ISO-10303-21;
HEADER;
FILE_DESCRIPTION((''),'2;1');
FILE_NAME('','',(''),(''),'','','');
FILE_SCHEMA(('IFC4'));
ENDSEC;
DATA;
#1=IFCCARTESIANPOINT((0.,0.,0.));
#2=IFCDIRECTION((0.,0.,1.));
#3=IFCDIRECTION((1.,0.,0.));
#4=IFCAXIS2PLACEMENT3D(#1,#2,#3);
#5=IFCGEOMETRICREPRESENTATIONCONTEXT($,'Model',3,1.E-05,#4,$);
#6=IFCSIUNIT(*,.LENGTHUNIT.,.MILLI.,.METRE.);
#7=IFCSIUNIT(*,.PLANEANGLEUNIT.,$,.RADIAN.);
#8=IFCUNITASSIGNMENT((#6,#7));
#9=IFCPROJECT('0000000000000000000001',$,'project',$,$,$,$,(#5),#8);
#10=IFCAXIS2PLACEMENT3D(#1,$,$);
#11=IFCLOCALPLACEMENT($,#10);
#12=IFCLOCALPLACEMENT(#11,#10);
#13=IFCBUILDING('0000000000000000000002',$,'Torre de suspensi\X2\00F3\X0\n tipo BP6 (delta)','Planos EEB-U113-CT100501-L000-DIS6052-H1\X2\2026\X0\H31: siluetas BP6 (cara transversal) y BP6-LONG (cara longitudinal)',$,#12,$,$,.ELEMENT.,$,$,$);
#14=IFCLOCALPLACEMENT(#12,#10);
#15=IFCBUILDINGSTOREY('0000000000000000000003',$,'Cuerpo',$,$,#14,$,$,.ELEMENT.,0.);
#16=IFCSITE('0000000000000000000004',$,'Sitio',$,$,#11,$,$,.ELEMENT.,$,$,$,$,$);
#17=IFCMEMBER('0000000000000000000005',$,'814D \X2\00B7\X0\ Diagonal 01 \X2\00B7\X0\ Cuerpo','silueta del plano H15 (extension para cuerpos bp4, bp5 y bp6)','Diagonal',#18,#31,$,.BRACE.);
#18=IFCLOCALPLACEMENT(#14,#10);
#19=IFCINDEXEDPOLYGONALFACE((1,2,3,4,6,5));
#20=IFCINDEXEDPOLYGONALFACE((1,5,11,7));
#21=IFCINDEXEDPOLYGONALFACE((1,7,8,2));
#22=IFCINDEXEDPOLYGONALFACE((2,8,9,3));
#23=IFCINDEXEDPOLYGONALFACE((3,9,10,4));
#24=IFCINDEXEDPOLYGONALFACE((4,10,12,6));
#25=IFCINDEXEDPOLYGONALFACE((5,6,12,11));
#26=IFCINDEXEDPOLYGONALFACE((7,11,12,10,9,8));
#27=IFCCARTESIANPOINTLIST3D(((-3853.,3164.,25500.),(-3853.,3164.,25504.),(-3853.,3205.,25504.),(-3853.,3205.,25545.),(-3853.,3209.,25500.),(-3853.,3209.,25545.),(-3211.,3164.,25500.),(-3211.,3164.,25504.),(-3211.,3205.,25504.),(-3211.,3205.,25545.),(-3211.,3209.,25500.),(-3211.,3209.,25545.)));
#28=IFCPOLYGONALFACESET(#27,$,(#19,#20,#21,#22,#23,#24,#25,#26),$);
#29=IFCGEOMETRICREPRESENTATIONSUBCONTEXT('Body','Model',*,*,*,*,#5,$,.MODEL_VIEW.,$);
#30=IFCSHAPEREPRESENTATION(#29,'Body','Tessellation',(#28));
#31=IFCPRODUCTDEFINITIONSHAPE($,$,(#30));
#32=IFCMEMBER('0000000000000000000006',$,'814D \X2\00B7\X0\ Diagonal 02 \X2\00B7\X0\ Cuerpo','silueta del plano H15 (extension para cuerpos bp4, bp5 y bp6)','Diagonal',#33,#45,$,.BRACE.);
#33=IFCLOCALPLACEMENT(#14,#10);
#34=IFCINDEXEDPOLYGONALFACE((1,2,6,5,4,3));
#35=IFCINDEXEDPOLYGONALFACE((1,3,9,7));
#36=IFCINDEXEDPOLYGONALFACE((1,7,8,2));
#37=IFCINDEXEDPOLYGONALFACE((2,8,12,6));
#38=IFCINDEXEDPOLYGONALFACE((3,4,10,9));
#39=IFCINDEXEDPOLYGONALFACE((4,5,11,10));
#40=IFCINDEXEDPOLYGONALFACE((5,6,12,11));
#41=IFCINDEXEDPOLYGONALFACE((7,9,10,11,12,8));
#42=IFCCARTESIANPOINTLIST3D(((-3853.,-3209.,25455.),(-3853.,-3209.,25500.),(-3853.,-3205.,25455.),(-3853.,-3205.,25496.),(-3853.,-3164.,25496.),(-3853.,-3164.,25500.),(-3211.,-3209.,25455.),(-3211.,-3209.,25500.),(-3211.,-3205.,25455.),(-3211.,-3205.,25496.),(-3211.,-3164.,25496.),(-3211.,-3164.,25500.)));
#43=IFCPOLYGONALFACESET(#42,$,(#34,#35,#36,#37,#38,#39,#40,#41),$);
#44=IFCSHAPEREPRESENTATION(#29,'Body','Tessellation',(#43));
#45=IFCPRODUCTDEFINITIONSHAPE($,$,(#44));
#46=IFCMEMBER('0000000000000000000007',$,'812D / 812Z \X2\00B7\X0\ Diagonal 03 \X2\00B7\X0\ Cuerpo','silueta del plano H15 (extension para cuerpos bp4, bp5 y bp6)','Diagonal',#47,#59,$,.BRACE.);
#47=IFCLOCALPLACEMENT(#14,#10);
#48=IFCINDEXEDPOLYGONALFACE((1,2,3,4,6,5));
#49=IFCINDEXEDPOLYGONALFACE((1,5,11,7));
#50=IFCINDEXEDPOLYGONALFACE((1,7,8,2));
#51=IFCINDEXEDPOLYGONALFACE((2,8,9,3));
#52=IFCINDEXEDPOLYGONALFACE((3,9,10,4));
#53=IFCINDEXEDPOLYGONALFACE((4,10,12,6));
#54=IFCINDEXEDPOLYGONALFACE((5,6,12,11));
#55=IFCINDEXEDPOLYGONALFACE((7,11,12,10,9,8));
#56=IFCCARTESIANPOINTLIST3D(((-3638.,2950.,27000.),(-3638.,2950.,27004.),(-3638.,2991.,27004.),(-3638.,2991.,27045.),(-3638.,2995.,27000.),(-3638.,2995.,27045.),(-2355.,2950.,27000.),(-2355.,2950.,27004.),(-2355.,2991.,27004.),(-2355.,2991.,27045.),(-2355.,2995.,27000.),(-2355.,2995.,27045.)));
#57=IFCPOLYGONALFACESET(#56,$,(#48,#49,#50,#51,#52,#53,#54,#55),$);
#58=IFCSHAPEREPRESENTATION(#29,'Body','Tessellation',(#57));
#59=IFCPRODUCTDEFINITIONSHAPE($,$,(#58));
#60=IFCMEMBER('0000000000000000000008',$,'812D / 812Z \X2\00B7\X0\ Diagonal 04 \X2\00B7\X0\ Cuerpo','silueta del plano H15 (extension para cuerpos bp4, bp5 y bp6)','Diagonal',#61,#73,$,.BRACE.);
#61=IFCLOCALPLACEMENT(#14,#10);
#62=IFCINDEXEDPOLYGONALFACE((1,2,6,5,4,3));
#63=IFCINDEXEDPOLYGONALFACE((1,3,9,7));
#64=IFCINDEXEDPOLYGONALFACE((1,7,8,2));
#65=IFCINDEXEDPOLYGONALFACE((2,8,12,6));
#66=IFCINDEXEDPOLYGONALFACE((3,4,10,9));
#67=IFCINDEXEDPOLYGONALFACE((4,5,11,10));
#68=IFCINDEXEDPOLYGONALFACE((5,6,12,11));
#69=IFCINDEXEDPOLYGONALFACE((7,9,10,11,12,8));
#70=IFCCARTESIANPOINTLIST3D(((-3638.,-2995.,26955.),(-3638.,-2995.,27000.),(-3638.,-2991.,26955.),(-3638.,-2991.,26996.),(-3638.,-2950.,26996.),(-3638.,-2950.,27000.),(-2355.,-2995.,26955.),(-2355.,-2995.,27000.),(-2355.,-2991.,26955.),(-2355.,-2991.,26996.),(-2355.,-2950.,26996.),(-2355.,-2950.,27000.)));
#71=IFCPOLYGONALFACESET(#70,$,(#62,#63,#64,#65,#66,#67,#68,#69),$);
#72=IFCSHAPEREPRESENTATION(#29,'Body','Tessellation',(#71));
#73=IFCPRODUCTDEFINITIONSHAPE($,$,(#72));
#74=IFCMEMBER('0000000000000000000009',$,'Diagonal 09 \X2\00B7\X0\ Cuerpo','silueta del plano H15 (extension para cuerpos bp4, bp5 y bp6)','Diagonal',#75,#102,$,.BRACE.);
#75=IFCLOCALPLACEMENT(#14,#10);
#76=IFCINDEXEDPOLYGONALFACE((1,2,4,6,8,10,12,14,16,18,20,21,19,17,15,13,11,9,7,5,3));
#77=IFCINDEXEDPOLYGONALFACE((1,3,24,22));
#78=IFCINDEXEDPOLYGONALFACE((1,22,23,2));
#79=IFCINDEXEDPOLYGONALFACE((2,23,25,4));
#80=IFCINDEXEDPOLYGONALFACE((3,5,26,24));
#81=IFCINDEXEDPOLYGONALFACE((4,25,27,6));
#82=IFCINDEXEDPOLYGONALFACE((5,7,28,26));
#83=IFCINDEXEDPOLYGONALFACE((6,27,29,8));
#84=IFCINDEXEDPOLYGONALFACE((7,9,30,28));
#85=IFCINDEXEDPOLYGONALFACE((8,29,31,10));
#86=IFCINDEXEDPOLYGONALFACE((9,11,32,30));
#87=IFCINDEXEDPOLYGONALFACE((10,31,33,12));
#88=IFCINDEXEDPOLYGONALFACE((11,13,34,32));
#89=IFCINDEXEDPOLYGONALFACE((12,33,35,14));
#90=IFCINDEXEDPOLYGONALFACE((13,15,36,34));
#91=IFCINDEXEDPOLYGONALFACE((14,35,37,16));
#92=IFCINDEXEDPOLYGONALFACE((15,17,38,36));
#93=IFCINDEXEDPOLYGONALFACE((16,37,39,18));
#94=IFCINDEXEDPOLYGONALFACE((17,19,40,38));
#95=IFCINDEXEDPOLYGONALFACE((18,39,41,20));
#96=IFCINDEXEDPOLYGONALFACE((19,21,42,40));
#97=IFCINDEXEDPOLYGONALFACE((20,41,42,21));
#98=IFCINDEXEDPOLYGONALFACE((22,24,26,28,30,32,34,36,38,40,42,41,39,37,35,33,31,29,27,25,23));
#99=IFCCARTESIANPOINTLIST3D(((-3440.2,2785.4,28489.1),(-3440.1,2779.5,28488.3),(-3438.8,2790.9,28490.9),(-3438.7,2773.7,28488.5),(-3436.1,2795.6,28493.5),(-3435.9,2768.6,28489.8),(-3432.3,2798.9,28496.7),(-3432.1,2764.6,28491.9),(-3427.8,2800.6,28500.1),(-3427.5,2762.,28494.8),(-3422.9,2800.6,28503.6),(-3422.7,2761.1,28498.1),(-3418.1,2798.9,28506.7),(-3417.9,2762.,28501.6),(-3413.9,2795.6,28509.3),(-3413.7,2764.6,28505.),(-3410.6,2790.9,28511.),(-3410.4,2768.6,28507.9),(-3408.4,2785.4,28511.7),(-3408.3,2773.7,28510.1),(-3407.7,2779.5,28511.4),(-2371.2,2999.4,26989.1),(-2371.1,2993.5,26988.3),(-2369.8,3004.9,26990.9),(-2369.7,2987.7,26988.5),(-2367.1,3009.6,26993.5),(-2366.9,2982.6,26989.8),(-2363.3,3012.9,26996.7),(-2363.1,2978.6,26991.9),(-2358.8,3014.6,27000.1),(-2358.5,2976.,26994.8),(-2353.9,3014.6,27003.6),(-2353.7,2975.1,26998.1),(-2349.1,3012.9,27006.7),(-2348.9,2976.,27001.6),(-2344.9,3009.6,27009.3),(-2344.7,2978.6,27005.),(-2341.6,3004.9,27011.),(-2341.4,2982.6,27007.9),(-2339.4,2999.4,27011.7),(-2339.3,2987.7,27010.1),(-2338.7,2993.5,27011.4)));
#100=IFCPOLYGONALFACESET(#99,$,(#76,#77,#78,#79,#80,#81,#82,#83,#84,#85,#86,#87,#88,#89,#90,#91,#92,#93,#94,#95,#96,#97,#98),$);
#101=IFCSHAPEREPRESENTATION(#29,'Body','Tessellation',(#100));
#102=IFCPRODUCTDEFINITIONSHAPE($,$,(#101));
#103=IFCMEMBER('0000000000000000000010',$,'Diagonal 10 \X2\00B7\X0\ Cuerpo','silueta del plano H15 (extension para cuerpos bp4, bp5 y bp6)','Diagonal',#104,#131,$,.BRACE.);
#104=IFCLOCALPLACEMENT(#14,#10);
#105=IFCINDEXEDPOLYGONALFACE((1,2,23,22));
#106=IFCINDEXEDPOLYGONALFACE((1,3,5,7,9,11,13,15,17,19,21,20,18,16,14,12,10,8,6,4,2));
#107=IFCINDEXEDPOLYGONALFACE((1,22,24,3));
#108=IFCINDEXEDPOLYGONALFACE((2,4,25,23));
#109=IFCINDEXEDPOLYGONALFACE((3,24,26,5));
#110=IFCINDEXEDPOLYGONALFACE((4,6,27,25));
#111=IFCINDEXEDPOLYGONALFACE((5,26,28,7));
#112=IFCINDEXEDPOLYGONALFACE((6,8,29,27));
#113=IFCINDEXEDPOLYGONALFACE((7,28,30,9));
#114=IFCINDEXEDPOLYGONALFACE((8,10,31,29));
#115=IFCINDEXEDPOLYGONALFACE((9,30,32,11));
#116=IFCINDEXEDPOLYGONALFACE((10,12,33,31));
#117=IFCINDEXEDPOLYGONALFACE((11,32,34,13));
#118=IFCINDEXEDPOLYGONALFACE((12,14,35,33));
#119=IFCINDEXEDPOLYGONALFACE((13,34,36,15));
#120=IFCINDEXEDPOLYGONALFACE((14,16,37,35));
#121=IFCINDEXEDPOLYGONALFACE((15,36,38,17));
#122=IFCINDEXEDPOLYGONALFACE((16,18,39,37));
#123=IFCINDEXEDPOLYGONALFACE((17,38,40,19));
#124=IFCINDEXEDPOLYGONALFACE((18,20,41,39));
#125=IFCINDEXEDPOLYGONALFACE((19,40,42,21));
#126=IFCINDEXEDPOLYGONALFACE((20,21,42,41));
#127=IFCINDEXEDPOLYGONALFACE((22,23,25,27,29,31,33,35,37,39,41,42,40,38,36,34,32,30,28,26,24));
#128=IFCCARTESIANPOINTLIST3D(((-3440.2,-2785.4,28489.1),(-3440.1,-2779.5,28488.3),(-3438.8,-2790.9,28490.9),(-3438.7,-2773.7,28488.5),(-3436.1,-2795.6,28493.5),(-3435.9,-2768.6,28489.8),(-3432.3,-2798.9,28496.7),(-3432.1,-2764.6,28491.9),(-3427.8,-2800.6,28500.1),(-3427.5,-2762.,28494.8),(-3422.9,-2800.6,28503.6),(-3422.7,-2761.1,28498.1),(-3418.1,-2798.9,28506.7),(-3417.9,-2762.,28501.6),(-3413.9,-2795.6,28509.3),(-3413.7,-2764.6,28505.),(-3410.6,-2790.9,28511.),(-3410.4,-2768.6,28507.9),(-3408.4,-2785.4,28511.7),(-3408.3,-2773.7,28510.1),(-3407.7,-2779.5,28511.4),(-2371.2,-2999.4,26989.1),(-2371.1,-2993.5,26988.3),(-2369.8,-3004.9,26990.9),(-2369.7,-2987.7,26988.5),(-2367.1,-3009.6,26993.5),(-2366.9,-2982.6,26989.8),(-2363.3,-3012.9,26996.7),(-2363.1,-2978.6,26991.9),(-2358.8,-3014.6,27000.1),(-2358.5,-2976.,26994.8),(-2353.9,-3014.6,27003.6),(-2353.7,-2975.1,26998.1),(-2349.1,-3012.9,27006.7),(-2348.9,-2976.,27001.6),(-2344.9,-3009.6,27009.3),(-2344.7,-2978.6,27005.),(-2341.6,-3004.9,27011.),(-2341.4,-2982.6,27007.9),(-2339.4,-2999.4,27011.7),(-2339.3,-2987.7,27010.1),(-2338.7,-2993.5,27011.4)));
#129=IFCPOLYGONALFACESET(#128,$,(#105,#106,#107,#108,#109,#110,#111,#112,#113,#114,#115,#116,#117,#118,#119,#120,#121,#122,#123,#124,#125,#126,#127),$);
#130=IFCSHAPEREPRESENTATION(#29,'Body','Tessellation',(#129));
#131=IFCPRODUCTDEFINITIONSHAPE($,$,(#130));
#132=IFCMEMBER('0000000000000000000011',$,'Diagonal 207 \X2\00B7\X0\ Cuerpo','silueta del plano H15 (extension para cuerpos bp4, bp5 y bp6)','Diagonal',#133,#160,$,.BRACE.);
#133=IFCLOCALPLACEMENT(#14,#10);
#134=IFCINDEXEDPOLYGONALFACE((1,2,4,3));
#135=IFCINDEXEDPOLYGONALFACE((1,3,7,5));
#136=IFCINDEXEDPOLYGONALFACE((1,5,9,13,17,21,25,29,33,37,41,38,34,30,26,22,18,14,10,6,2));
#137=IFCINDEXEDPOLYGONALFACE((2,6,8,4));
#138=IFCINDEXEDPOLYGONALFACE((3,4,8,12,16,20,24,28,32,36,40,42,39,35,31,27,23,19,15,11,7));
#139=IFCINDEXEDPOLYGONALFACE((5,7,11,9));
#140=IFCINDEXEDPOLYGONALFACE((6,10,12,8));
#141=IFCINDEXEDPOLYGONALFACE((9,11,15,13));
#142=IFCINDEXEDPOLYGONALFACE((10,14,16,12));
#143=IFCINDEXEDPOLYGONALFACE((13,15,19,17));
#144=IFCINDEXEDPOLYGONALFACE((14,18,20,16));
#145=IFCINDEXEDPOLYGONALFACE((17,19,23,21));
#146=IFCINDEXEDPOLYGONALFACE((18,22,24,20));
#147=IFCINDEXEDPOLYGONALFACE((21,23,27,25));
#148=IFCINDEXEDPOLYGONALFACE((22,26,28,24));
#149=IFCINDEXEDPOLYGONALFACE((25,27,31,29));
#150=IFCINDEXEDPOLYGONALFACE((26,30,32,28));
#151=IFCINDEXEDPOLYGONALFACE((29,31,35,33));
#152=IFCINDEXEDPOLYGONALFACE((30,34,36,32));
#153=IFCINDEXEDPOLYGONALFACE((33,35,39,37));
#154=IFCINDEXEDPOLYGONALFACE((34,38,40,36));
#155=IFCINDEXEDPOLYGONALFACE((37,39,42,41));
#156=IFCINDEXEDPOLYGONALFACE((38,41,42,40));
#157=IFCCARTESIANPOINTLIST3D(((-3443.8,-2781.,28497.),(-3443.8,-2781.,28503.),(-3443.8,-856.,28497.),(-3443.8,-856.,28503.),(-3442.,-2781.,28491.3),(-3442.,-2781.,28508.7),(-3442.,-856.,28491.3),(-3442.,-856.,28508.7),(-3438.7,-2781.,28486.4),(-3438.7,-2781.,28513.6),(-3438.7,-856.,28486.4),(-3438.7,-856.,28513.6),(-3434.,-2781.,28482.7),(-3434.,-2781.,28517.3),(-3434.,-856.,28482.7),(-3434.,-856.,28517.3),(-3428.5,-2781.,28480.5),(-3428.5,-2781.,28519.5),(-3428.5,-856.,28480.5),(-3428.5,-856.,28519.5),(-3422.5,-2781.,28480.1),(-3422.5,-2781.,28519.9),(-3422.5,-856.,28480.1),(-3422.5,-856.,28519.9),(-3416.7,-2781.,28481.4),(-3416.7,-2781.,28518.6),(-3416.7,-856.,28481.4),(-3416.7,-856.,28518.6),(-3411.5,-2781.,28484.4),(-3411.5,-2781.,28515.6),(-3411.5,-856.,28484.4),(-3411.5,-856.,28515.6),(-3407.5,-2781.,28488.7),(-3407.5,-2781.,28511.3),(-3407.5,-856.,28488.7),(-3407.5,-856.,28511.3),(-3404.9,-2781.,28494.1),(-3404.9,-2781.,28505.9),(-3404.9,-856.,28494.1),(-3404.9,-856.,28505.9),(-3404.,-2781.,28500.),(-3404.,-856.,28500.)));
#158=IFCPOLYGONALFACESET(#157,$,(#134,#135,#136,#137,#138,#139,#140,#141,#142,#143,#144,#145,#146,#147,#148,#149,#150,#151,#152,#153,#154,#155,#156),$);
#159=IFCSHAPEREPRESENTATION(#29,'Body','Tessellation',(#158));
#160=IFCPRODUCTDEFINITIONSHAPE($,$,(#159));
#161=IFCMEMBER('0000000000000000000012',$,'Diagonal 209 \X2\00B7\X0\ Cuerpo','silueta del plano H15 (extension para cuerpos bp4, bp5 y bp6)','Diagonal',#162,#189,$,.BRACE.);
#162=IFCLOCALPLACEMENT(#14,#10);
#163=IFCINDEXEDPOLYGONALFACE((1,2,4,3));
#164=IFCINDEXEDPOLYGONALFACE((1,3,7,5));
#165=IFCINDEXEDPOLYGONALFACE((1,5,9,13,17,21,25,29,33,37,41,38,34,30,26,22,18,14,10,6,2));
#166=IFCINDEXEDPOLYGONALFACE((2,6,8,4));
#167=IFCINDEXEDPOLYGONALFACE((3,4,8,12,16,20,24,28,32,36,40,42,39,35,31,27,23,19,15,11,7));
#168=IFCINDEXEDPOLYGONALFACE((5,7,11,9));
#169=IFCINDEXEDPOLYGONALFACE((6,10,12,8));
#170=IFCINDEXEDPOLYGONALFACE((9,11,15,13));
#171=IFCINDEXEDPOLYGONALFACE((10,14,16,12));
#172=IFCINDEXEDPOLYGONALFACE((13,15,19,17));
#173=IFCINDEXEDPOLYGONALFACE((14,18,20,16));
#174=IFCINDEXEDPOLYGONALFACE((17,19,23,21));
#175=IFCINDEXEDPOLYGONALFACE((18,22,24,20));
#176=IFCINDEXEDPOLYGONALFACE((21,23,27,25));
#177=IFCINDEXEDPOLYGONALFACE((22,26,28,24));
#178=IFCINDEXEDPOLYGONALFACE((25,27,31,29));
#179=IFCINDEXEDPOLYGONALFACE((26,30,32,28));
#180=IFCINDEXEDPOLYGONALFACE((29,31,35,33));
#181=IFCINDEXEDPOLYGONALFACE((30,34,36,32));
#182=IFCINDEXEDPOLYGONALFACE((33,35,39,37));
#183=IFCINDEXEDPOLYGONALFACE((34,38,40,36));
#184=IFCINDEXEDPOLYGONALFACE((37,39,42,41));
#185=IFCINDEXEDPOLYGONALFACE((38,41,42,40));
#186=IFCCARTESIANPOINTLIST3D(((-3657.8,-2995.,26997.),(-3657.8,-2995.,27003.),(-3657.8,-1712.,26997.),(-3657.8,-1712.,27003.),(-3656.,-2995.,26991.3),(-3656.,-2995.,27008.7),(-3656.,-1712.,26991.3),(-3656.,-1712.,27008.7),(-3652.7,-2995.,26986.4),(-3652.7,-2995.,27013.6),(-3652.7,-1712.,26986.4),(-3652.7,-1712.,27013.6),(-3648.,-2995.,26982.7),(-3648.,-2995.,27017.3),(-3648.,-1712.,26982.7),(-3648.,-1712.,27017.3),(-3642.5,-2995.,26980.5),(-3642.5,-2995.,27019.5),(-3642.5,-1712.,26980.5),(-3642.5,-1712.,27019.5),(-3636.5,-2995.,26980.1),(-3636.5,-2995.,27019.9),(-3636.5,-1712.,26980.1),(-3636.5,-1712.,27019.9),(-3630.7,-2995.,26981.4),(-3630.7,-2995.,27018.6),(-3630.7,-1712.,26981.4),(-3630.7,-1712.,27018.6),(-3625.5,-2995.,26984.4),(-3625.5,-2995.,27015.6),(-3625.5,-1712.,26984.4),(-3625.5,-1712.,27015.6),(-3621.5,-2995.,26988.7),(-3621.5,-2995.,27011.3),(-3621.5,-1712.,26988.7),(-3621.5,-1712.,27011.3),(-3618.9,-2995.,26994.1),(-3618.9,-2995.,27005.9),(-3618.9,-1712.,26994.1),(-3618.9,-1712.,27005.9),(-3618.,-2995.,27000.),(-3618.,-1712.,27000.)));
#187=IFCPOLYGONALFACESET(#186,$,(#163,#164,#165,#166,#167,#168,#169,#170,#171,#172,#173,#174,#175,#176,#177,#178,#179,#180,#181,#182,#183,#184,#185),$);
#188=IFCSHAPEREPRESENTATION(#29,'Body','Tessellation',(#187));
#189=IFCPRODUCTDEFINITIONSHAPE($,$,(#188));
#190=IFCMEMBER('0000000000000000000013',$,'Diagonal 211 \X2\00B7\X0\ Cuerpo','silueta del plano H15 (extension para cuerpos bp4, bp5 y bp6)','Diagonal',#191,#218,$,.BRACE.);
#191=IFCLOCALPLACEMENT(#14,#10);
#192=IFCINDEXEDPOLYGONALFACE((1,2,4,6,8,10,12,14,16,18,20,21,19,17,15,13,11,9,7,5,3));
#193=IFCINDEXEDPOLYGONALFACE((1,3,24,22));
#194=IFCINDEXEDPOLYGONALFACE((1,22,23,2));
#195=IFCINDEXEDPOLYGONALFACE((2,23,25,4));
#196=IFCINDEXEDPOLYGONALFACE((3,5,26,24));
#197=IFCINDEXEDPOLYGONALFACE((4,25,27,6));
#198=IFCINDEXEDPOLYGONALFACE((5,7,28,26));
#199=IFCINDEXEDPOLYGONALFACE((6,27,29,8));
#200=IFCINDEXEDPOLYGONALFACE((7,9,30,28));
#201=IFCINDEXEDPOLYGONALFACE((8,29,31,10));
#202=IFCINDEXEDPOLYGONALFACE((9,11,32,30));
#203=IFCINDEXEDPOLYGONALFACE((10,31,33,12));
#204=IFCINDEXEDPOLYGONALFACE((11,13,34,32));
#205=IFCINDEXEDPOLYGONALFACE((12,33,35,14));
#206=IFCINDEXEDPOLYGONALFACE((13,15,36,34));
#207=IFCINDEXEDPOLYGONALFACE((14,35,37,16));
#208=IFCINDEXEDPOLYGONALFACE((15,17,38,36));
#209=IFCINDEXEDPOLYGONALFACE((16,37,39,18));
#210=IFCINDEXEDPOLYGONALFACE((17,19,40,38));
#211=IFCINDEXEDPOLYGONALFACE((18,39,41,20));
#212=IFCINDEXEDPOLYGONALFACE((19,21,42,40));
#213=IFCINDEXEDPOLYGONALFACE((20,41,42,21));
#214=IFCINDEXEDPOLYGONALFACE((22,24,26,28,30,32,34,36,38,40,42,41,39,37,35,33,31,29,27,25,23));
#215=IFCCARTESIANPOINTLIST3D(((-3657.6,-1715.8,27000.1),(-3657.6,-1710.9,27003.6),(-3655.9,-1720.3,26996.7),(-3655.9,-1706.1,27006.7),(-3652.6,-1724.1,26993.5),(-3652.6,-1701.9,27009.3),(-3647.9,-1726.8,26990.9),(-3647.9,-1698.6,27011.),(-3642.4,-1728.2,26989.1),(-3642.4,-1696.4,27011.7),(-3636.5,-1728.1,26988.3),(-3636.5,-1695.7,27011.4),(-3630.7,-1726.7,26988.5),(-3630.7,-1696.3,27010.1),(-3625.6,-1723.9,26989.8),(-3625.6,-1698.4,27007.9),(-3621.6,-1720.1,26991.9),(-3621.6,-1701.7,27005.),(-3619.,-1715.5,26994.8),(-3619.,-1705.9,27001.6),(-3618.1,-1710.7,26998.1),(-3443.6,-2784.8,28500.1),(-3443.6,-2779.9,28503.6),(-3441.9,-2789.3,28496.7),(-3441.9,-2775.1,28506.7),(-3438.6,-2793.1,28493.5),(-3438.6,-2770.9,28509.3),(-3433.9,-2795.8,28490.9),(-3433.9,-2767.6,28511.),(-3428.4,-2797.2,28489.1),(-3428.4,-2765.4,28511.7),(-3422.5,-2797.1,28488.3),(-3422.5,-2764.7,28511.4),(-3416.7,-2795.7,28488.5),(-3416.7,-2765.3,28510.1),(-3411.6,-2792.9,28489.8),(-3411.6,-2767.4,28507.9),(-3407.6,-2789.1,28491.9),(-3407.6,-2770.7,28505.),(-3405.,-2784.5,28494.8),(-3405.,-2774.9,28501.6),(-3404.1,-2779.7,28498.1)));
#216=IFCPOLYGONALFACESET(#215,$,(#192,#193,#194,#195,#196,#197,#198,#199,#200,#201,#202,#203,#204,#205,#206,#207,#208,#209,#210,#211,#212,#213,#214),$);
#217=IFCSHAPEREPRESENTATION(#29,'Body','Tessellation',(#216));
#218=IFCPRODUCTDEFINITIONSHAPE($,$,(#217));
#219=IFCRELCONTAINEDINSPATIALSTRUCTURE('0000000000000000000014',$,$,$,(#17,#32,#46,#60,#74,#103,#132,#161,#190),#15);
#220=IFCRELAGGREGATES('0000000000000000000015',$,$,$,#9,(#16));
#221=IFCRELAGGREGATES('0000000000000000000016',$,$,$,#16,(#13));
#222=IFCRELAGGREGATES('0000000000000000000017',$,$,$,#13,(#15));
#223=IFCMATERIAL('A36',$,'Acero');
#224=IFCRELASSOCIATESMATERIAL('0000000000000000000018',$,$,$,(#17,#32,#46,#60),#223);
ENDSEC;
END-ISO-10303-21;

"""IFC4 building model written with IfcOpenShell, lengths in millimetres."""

from ifc_helpers import new_model, si_unit, frame, frame_2d, origin, origin_with_axes, place, context, subcontext, project, spatial, circle, l_section, extrude, material, element, save


model = new_model("IFC4")

# Units and contexts
model_context = context("Model", 3, precision=1e-05, world=origin_with_axes())
body_context = subcontext(model_context, "Body", "Model", "MODEL_VIEW")
ifc_project = project(units=[si_unit("LENGTHUNIT", "METRE", prefix="MILLI"), si_unit("PLANEANGLEUNIT", "RADIAN")], contexts=[model_context])

# Site, building, storey
site_placement = place(None, origin())
site = spatial("IfcSite", under=ifc_project, at=site_placement, Name="Sitio", CompositionType="ELEMENT")
building_placement = place(site_placement, origin())
building = spatial("IfcBuilding", under=site, at=building_placement, Name="Torre de suspensión tipo BP6 (delta)", Description="Planos EEB-U113-CT100501-L000-DIS6052-H1…H31: siluetas BP6 (cara transversal) y BP6-LONG (cara longitudinal)", CompositionType="ELEMENT")
storey_placement = place(building_placement, origin())
storey = spatial("IfcBuildingStorey", under=building, at=storey_placement, Name="Cuerpo", CompositionType="ELEMENT", Elevation=0.0)

# Members
ifc_material = material(Name="A36", Category="Acero")
for number, where, z_axis, x_axis, name in (
    (1, (-3211.0, 3209.0, 25500.0), (-1.0, 0.0, 0.0), (0.0, -1.0, 0.0), "814D · Diagonal 01 · Cuerpo"),
    (2, (-3211.0, -3209.0, 25500.0), (-1.0, 0.0, 0.0), (0.0, 1.0, 0.0), "814D · Diagonal 02 · Cuerpo"),
):
    element("IfcMember", number, at=place(storey_placement, frame(where, z_axis=z_axis, x_axis=x_axis)), inside=storey, material=ifc_material, Name=name, Description="silueta del plano H15 (extension para cuerpos bp4, bp5 y bp6)", ObjectType="Diagonal", PredefinedType="BRACE", context=body_context, shape_type="SweptSolid", body=[
        extrude(l_section(Depth=45.0, Width=45.0, Thickness=4.0, at=frame_2d((22.5, 22.5))), None, (0.0, 0.0, 1.0), 642.0),
    ])
for number, where, z_axis, x_axis, name in (
    (3, (-2355.0, 2995.0, 27000.0), (-1.0, 0.0, 0.0), (0.0, -1.0, 0.0), "812D / 812Z · Diagonal 03 · Cuerpo"),
    (4, (-2355.0, -2995.0, 27000.0), (-1.0, 0.0, 0.0), (0.0, 1.0, 0.0), "812D / 812Z · Diagonal 04 · Cuerpo"),
):
    element("IfcMember", number, at=place(storey_placement, frame(where, z_axis=z_axis, x_axis=x_axis)), inside=storey, material=ifc_material, Name=name, Description="silueta del plano H15 (extension para cuerpos bp4, bp5 y bp6)", ObjectType="Diagonal", PredefinedType="BRACE", context=body_context, shape_type="SweptSolid", body=[
        extrude(l_section(Depth=45.0, Width=45.0, Thickness=4.0, at=frame_2d((22.5, 22.5))), None, (0.0, 0.0, 1.0), 1283.0),
    ])
for number, where, z_axis, x_axis, name in (
    (5, (-2355.0, 2995.0, 27000.0), (-0.576487, -0.115405, 0.808915), (0.066977, -0.993318, -0.093981), "Diagonal 09 · Cuerpo"),
    (6, (-2355.0, -2995.0, 27000.0), (-0.576487, 0.115405, 0.808915), (0.066977, 0.993318, -0.093981), "Diagonal 10 · Cuerpo"),
):
    element("IfcMember", number, at=place(storey_placement, frame(where, z_axis=z_axis, x_axis=x_axis)), inside=storey, Name=name, Description="silueta del plano H15 (extension para cuerpos bp4, bp5 y bp6)", ObjectType="Diagonal", PredefinedType="BRACE", context=body_context, shape_type="SweptSolid", body=[
        extrude(circle(Radius=20.0), None, (0.0, 0.0, 1.0), 1854.3),
    ])
member_1_placement = place(storey_placement, frame((-3424.0, -856.0, 28500.0), z_axis=(0.0, -1.0, 0.0), x_axis=(1.0, 0.0, 0.0)))
element("IfcMember", 7, at=member_1_placement, inside=storey, Name="Diagonal 207 · Cuerpo", Description="silueta del plano H15 (extension para cuerpos bp4, bp5 y bp6)", ObjectType="Diagonal", PredefinedType="BRACE", context=body_context, shape_type="SweptSolid", body=[
    extrude(circle(Radius=20.0), None, (0.0, 0.0, 1.0), 1925.0),
])
member_2_placement = place(storey_placement, frame((-3638.0, -1712.0, 27000.0), z_axis=(0.0, -1.0, 0.0), x_axis=(1.0, 0.0, 0.0)))
element("IfcMember", 8, at=member_2_placement, inside=storey, Name="Diagonal 209 · Cuerpo", Description="silueta del plano H15 (extension para cuerpos bp4, bp5 y bp6)", ObjectType="Diagonal", PredefinedType="BRACE", context=body_context, shape_type="SweptSolid", body=[
    extrude(circle(Radius=20.0), None, (0.0, 0.0, 1.0), 1283.0),
])
member_3_placement = place(storey_placement, frame((-3638.0, -1712.0, 27000.0), z_axis=(0.115405, -0.576487, 0.808915), x_axis=(0.993318, 0.066977, -0.093981)))
element("IfcMember", 9, at=member_3_placement, inside=storey, Name="Diagonal 211 · Cuerpo", Description="silueta del plano H15 (extension para cuerpos bp4, bp5 y bp6)", ObjectType="Diagonal", PredefinedType="BRACE", context=body_context, shape_type="SweptSolid", body=[
    extrude(circle(Radius=20.0), None, (0.0, 0.0, 1.0), 1854.3),
])

save(model, "model.ifc")
